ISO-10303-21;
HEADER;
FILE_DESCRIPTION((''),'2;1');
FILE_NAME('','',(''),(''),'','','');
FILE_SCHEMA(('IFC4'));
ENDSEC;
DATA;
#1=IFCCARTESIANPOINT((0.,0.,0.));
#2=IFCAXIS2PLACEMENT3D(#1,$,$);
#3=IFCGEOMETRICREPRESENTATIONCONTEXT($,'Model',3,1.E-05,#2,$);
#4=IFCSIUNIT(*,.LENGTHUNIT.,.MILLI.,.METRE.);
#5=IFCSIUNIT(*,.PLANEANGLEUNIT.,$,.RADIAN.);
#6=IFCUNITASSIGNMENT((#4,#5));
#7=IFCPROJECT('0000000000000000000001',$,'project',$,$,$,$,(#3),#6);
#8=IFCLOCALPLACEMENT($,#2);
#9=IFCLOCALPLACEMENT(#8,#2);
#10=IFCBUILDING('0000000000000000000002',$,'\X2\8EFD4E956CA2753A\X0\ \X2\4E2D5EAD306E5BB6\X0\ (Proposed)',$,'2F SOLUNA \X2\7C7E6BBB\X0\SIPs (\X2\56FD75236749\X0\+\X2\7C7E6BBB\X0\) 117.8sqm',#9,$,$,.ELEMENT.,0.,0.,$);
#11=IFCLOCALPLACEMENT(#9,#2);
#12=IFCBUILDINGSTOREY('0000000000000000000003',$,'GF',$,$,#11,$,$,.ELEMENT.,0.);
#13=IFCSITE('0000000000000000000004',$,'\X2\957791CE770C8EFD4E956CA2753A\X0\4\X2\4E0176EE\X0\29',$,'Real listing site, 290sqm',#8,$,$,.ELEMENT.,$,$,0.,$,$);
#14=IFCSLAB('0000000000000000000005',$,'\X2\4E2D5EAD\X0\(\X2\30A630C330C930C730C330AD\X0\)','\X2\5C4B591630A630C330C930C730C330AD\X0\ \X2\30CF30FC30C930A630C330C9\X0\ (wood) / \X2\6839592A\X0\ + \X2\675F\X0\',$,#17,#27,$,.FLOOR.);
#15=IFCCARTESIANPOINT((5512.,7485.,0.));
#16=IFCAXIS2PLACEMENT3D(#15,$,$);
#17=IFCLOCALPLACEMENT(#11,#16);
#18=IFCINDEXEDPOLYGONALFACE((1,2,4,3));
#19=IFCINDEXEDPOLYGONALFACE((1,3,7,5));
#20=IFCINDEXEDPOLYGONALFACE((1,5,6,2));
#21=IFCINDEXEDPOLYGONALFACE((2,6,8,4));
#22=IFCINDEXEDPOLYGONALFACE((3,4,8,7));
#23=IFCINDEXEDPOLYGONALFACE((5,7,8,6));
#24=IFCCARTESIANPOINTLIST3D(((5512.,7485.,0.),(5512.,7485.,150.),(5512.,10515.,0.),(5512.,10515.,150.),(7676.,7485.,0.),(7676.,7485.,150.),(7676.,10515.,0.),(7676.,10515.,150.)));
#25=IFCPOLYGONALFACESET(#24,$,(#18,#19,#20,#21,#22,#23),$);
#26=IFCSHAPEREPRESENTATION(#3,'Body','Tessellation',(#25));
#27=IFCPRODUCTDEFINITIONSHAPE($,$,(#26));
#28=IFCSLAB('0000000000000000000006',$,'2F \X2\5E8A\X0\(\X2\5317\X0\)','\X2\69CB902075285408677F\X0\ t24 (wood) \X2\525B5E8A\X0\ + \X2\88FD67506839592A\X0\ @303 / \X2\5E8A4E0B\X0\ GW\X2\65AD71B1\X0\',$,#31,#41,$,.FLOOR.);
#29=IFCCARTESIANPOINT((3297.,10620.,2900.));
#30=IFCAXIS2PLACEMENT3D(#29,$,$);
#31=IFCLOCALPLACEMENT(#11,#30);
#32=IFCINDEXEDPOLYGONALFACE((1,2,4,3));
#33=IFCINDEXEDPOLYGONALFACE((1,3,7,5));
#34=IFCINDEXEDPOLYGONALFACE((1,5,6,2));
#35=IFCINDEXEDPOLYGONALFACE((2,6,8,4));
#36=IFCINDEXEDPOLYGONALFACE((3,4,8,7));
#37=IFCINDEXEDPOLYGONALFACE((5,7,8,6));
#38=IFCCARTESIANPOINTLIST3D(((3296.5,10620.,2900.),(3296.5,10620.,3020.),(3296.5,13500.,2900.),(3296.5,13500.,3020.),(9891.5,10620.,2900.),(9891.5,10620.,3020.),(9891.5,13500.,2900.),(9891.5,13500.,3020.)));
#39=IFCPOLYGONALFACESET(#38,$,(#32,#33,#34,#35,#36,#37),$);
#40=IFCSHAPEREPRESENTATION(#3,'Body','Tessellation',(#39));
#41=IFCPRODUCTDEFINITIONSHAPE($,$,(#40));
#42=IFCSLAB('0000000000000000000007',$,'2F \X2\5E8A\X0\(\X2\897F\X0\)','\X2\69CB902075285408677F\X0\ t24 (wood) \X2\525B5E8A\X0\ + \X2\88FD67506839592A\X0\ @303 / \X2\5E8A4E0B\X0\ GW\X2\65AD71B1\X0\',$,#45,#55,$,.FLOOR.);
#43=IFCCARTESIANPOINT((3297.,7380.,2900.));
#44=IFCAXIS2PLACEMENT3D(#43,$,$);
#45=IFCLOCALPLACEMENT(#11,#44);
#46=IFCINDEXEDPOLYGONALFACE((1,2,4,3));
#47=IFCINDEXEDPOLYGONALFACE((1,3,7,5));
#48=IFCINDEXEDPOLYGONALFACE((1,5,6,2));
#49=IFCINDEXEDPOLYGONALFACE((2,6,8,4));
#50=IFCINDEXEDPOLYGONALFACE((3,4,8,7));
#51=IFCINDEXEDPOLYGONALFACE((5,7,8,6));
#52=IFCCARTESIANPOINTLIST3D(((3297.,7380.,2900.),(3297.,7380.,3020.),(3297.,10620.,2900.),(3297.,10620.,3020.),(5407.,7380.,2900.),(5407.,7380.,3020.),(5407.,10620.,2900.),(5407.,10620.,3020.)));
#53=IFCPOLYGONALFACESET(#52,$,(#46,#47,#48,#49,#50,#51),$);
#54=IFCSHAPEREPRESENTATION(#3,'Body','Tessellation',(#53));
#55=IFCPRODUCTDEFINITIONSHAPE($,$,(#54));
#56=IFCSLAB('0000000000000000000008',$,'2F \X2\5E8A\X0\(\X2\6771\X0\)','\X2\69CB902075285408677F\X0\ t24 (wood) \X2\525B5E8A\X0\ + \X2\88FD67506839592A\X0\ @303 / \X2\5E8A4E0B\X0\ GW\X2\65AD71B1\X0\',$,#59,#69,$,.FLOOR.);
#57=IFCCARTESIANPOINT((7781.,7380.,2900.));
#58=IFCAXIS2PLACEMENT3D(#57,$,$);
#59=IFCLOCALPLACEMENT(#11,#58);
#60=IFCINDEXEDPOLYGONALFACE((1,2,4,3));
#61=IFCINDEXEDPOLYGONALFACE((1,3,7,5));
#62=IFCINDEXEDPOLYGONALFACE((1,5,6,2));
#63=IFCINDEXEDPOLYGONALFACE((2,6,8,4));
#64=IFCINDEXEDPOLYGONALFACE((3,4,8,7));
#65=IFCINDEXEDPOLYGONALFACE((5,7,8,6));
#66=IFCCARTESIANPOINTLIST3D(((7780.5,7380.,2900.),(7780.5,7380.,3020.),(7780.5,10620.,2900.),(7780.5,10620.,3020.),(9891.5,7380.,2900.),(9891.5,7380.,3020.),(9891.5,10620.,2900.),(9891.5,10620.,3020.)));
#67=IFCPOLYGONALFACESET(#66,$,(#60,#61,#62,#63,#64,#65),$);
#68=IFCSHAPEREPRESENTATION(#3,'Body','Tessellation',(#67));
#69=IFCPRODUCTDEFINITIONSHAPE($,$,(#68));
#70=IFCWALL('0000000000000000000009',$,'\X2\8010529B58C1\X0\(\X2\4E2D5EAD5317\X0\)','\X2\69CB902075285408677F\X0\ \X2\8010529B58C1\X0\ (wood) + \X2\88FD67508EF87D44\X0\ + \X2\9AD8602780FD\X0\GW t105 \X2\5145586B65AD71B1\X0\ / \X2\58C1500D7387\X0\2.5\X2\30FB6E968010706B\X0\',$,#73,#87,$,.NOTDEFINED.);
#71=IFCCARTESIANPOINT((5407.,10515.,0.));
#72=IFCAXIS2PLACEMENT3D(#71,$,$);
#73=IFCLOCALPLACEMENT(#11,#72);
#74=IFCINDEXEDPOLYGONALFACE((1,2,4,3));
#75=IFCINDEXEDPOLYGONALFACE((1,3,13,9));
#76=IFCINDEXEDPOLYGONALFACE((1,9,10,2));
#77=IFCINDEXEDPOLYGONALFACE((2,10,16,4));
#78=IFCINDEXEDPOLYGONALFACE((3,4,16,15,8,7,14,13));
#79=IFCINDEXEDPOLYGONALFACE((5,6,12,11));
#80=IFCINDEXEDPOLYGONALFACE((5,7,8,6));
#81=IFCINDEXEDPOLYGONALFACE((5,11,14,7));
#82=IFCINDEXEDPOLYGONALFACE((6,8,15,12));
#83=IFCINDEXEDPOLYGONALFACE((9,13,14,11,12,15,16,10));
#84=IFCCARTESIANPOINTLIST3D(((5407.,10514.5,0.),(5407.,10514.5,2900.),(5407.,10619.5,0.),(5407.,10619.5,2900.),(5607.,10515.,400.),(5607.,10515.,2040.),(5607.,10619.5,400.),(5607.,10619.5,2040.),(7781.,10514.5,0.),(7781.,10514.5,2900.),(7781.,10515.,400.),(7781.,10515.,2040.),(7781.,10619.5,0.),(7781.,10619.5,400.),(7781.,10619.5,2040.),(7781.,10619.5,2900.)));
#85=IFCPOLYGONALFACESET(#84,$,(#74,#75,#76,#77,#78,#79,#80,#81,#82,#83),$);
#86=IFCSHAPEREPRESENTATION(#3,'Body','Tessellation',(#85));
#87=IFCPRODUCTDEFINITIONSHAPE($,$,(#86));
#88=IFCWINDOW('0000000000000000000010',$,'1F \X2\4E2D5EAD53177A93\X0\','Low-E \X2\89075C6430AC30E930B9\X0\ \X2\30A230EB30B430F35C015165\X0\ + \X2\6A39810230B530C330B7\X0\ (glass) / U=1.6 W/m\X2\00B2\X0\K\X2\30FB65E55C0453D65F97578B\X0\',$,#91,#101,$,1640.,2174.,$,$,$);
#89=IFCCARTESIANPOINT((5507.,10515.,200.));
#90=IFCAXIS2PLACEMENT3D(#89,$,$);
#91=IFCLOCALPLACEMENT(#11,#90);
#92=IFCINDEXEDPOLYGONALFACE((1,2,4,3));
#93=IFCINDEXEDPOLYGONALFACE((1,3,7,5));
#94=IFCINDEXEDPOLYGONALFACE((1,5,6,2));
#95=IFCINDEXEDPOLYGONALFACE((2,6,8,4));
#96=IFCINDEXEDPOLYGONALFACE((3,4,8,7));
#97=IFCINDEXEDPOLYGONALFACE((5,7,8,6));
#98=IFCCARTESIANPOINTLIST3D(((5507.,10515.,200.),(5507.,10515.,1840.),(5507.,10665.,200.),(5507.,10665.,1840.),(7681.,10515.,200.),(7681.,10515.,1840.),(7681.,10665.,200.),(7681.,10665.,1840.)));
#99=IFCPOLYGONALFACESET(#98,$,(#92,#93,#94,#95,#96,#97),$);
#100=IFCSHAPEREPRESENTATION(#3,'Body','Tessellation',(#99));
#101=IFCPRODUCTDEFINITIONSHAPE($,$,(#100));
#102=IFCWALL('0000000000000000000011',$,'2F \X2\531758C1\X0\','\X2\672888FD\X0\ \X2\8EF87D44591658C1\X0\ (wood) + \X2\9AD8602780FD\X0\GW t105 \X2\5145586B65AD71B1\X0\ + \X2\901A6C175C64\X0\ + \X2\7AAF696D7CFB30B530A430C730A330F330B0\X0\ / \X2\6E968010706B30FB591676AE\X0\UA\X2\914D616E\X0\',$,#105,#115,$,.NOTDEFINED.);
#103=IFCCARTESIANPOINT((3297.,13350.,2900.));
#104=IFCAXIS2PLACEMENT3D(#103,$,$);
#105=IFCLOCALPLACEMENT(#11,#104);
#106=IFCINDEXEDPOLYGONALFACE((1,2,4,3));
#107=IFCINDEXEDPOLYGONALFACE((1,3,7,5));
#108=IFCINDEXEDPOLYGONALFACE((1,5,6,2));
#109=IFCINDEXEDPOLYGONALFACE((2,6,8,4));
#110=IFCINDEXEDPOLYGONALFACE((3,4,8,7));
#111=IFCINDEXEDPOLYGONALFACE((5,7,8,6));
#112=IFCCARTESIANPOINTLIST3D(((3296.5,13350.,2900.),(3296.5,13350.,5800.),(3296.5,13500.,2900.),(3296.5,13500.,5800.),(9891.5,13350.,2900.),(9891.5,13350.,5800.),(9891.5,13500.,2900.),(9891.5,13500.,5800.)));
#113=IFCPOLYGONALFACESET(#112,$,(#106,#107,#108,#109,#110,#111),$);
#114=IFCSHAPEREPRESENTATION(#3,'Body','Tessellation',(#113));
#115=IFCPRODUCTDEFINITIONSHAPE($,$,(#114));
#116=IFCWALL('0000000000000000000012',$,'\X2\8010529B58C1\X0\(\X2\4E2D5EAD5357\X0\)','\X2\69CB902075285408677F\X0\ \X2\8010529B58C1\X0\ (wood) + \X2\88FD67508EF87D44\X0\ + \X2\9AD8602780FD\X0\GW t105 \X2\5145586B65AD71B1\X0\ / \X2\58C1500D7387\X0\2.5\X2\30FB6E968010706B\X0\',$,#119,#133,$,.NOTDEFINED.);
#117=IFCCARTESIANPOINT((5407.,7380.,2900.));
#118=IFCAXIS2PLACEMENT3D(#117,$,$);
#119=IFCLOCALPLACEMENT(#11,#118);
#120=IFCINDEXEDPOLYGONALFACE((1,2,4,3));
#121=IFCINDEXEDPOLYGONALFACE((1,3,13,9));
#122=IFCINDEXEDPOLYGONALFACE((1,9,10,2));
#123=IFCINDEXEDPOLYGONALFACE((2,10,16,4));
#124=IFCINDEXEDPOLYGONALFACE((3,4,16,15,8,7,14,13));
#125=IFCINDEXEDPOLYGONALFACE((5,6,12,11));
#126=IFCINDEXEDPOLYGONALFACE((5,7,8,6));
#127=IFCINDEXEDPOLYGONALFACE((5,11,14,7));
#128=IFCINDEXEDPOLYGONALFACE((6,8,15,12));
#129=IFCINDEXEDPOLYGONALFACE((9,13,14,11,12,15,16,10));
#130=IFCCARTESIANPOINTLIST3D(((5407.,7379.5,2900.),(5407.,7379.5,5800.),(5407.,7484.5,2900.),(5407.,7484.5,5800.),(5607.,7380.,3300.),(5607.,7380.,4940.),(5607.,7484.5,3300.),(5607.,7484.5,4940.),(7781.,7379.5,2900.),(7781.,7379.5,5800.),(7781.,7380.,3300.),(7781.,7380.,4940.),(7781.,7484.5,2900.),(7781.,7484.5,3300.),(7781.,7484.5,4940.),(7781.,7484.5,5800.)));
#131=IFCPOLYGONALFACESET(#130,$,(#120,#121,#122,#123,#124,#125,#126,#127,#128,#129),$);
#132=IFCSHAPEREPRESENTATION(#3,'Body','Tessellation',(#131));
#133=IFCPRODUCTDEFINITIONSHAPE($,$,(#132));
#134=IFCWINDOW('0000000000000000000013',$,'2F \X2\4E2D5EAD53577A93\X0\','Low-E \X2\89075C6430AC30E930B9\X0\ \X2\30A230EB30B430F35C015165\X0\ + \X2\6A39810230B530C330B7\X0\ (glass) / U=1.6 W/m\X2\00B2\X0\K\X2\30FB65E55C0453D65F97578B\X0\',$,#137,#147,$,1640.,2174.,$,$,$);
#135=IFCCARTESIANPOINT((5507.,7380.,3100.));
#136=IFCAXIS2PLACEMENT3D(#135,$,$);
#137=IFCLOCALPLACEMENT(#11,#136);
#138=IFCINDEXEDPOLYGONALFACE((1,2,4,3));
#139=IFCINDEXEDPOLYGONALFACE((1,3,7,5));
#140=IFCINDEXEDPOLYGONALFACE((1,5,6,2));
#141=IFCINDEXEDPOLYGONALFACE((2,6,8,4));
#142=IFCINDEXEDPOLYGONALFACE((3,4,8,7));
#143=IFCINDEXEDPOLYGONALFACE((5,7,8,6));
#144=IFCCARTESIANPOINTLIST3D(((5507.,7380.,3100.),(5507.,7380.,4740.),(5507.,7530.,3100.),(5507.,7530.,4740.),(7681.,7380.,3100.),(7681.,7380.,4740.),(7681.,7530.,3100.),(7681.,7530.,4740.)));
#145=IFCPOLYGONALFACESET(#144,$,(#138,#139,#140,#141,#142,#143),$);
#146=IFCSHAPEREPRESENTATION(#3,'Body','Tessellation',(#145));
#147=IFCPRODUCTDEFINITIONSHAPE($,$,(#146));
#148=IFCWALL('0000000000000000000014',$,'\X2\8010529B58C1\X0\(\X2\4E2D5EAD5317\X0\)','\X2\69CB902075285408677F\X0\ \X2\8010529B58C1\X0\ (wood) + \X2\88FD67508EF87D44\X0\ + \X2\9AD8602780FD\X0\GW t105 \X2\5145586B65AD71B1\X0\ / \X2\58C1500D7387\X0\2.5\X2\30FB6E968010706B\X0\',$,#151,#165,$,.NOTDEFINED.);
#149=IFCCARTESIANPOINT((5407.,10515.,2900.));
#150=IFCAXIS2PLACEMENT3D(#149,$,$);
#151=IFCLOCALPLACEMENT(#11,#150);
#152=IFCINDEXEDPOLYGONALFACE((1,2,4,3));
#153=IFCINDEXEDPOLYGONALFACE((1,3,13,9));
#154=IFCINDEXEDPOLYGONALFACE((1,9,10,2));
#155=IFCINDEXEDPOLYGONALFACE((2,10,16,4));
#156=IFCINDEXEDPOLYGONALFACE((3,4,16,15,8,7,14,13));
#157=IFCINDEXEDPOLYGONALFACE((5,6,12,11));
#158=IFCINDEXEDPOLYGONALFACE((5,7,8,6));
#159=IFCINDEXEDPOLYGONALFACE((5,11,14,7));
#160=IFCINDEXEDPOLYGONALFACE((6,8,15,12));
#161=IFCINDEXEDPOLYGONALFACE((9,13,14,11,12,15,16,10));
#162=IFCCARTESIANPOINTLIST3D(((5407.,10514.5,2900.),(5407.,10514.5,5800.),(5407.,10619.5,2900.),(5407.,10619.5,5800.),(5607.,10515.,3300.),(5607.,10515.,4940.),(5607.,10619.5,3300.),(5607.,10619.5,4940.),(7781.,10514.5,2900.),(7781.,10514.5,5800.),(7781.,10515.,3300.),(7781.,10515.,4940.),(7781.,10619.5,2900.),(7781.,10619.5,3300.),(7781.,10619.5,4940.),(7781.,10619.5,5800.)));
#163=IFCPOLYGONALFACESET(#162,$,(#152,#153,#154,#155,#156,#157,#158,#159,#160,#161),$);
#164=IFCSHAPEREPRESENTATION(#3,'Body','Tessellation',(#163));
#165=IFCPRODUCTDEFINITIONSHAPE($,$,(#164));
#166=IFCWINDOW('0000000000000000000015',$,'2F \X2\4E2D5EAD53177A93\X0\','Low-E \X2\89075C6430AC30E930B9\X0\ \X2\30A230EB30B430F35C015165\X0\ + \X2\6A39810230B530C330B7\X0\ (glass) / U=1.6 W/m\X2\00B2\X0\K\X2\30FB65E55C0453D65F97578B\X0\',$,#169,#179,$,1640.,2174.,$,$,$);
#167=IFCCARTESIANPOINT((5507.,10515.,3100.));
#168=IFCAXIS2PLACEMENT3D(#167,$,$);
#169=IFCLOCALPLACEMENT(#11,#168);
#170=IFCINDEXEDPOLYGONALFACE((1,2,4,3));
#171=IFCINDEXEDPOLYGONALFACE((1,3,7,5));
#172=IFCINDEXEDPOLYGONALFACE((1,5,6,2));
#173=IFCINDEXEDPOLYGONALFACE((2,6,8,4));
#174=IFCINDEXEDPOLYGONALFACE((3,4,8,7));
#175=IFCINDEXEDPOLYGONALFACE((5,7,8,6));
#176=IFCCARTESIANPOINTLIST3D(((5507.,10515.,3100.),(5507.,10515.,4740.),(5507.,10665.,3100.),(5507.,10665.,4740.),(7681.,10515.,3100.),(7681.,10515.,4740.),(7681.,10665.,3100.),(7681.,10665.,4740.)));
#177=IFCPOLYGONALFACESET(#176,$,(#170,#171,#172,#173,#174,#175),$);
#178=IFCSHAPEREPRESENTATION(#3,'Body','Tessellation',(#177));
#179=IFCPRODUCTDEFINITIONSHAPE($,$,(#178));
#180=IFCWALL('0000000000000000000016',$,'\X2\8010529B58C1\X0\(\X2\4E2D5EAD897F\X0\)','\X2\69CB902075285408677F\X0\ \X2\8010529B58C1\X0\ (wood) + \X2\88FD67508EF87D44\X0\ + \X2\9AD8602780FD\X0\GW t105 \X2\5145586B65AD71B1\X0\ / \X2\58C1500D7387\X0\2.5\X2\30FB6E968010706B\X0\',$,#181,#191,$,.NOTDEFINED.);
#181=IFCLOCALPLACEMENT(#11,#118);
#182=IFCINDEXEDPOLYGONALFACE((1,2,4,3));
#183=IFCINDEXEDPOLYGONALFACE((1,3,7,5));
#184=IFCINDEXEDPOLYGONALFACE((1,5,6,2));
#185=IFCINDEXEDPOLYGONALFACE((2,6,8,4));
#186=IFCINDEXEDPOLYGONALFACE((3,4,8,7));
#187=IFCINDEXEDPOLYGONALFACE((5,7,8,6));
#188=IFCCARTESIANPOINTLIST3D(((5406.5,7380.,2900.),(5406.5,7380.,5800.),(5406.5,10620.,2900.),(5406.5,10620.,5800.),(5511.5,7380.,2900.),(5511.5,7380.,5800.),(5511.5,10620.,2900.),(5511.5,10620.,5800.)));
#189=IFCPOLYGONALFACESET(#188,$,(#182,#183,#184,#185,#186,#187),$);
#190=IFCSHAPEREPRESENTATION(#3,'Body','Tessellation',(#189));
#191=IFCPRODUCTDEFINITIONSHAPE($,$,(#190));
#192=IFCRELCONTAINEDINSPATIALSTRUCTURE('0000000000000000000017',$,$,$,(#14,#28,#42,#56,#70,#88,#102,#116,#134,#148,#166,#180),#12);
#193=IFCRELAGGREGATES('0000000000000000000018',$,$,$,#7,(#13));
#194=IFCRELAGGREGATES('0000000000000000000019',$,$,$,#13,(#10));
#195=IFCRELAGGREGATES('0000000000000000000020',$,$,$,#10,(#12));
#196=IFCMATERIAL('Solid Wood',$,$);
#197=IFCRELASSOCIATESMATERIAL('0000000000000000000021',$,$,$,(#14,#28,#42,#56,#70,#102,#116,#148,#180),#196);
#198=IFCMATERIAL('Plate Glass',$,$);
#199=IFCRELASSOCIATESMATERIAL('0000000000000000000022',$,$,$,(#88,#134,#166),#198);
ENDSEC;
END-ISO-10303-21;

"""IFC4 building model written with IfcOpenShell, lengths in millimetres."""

from ifc_helpers import new_model, si_unit, frame, frame_2d, origin, place, context, project, spatial, rectangle, extrude, material, element, fill, save


model = new_model("IFC4")

# Units and contexts
model_context = context("Model", 3, precision=1e-05, world=origin())
ifc_project = project(units=[si_unit("LENGTHUNIT", "METRE", prefix="MILLI"), si_unit("PLANEANGLEUNIT", "RADIAN")], contexts=[model_context])

# Site, building, storey
site_placement = place(None, origin())
site = spatial("IfcSite", under=ifc_project, at=site_placement, Name="長野県軽井沢町4丁目29", ObjectType="Real listing site, 290sqm", CompositionType="ELEMENT", RefElevation=0.0)
building_placement = place(site_placement, origin())
building = spatial("IfcBuilding", under=site, at=building_placement, Name="軽井沢町 中庭の家 (Proposed)", ObjectType="2F SOLUNA 籾殻SIPs (国産杉+籾殻) 117.8sqm", CompositionType="ELEMENT", ElevationOfRefHeight=0.0, ElevationOfTerrain=0.0)
storey_placement = place(building_placement, origin())
storey = spatial("IfcBuildingStorey", under=building, at=storey_placement, Name="GF", CompositionType="ELEMENT", Elevation=0.0)

# Slabs
ifc_material_1 = material(Name="Solid Wood")
slab_1_placement = place(storey_placement, frame((5512.0, 7485.0, 0.0)))
element("IfcSlab", 1, at=slab_1_placement, inside=storey, material=ifc_material_1, Name="中庭(ウッドデッキ)", Description="屋外ウッドデッキ ハードウッド (wood) / 根太 + 束", PredefinedType="FLOOR", context=model_context, shape_type="SweptSolid", body=[
    extrude(rectangle(XDim=2164.0, YDim=3030.0, at=frame_2d((1082.0, 1515.0))), frame((5512.0, 7485.0, 0.0)), (0.0, 0.0, 1.0), 150.0),
])
slab_2_placement = place(storey_placement, frame((3297.0, 10620.0, 2900.0)))
element("IfcSlab", 2, at=slab_2_placement, inside=storey, material=ifc_material_1, Name="2F 床(北)", Description="構造用合板 t24 (wood) 剛床 + 製材根太 @303 / 床下 GW断熱", PredefinedType="FLOOR", context=model_context, shape_type="SweptSolid", body=[
    extrude(rectangle(XDim=6595.0, YDim=2880.0, at=frame_2d((3297.0, 1440.0))), frame((3297.0, 10620.0, 2900.0)), (0.0, 0.0, 1.0), 120.0),
])
slab_3_placement = place(storey_placement, frame((3297.0, 7380.0, 2900.0)))
element("IfcSlab", 3, at=slab_3_placement, inside=storey, material=ifc_material_1, Name="2F 床(西)", Description="構造用合板 t24 (wood) 剛床 + 製材根太 @303 / 床下 GW断熱", PredefinedType="FLOOR", context=model_context, shape_type="SweptSolid", body=[
    extrude(rectangle(XDim=2110.0, YDim=3240.0, at=frame_2d((1055.0, 1620.0))), frame((3297.0, 7380.0, 2900.0)), (0.0, 0.0, 1.0), 120.0),
])
slab_4_placement = place(storey_placement, frame((7781.0, 7380.0, 2900.0)))
element("IfcSlab", 4, at=slab_4_placement, inside=storey, material=ifc_material_1, Name="2F 床(東)", Description="構造用合板 t24 (wood) 剛床 + 製材根太 @303 / 床下 GW断熱", PredefinedType="FLOOR", context=model_context, shape_type="SweptSolid", body=[
    extrude(rectangle(XDim=2111.0, YDim=3240.0, at=frame_2d((1055.0, 1620.0))), frame((7781.0, 7380.0, 2900.0)), (0.0, 0.0, 1.0), 120.0),
])

# Wall, opening, window
wall_1_placement = place(storey_placement, frame((5407.0, 10515.0, 0.0)))
wall_1 = element("IfcWall", 5, at=wall_1_placement, inside=storey, material=ifc_material_1, Name="耐力壁(中庭北)", Description="構造用合板 耐力壁 (wood) + 製材軸組 + 高性能GW t105 充填断熱 / 壁倍率2.5・準耐火", PredefinedType="NOTDEFINED", context=model_context, shape_type="SweptSolid", body=[
    extrude(rectangle(XDim=2374.0, YDim=105.0, at=frame_2d((1187.0, 52.0))), frame((5407.0, 10515.0, 0.0)), (0.0, 0.0, 1.0), 2900.0),
])
opening_1_placement = place(storey_placement, frame((5507.0, 10515.0, 200.0)))
opening_1 = element("IfcOpeningElement", 6, at=opening_1_placement, cuts=wall_1, PredefinedType="NOTDEFINED", context=model_context, shape_type="SweptSolid", body=[
    extrude(rectangle(XDim=2174.0, YDim=150.0, at=frame_2d((1087.0, 75.0))), frame((5507.0, 10515.0, 200.0)), (0.0, 0.0, 1.0), 1640.0),
])
ifc_material_2 = material(Name="Plate Glass")
window_1_placement = place(storey_placement, frame((5507.0, 10515.0, 200.0)))
window_1 = element("IfcWindow", 7, at=window_1_placement, inside=storey, material=ifc_material_2, Name="1F 中庭北窓", Description="Low-E 複層ガラス アルゴン封入 + 樹脂サッシ (glass) / U=1.6 W/m²K・日射取得型", OverallHeight=1640.0, OverallWidth=2174.0, context=model_context, shape_type="SweptSolid", body=[
    extrude(rectangle(XDim=2174.0, YDim=150.0, at=frame_2d((1087.0, 75.0))), frame((5507.0, 10515.0, 200.0)), (0.0, 0.0, 1.0), 1640.0),
])
fill(opening_1, window_1)

# Wall
wall_2_placement = place(storey_placement, frame((3297.0, 13350.0, 2900.0)))
element("IfcWall", 8, at=wall_2_placement, inside=storey, material=ifc_material_1, Name="2F 北壁", Description="木製 軸組外壁 (wood) + 高性能GW t105 充填断熱 + 通気層 + 窯業系サイディング / 準耐火・外皮UA配慮", PredefinedType="NOTDEFINED", context=model_context, shape_type="SweptSolid", body=[
    extrude(rectangle(XDim=6595.0, YDim=150.0, at=frame_2d((3297.0, 75.0))), frame((3297.0, 13350.0, 2900.0)), (0.0, 0.0, 1.0), 2900.0),
])

# Walls, openings, windows
wall_3_placement = place(storey_placement, frame((5407.0, 7380.0, 2900.0)))
wall_3 = element("IfcWall", 9, at=wall_3_placement, inside=storey, material=ifc_material_1, Name="耐力壁(中庭南)", Description="構造用合板 耐力壁 (wood) + 製材軸組 + 高性能GW t105 充填断熱 / 壁倍率2.5・準耐火", PredefinedType="NOTDEFINED", context=model_context, shape_type="SweptSolid", body=[
    extrude(rectangle(XDim=2374.0, YDim=105.0, at=frame_2d((1187.0, 52.0))), frame((5407.0, 7380.0, 2900.0)), (0.0, 0.0, 1.0), 2900.0),
])
opening_2_placement = place(storey_placement, frame((5507.0, 7380.0, 3100.0)))
opening_2 = element("IfcOpeningElement", 10, at=opening_2_placement, cuts=wall_3, PredefinedType="NOTDEFINED", context=model_context, shape_type="SweptSolid", body=[
    extrude(rectangle(XDim=2174.0, YDim=150.0, at=frame_2d((1087.0, 75.0))), frame((5507.0, 7380.0, 3100.0)), (0.0, 0.0, 1.0), 1640.0),
])
window_2_placement = place(storey_placement, frame((5507.0, 7380.0, 3100.0)))
window_2 = element("IfcWindow", 11, at=window_2_placement, inside=storey, material=ifc_material_2, Name="2F 中庭南窓", Description="Low-E 複層ガラス アルゴン封入 + 樹脂サッシ (glass) / U=1.6 W/m²K・日射取得型", OverallHeight=1640.0, OverallWidth=2174.0, context=model_context, shape_type="SweptSolid", body=[
    extrude(rectangle(XDim=2174.0, YDim=150.0, at=frame_2d((1087.0, 75.0))), frame((5507.0, 7380.0, 3100.0)), (0.0, 0.0, 1.0), 1640.0),
])
fill(opening_2, window_2)
wall_4_placement = place(storey_placement, frame((5407.0, 10515.0, 2900.0)))
wall_4 = element("IfcWall", 12, at=wall_4_placement, inside=storey, material=ifc_material_1, Name="耐力壁(中庭北)", Description="構造用合板 耐力壁 (wood) + 製材軸組 + 高性能GW t105 充填断熱 / 壁倍率2.5・準耐火", PredefinedType="NOTDEFINED", context=model_context, shape_type="SweptSolid", body=[
    extrude(rectangle(XDim=2374.0, YDim=105.0, at=frame_2d((1187.0, 52.0))), frame((5407.0, 10515.0, 2900.0)), (0.0, 0.0, 1.0), 2900.0),
])
opening_3_placement = place(storey_placement, frame((5507.0, 10515.0, 3100.0)))
opening_3 = element("IfcOpeningElement", 13, at=opening_3_placement, cuts=wall_4, PredefinedType="NOTDEFINED", context=model_context, shape_type="SweptSolid", body=[
    extrude(rectangle(XDim=2174.0, YDim=150.0, at=frame_2d((1087.0, 75.0))), frame((5507.0, 10515.0, 3100.0)), (0.0, 0.0, 1.0), 1640.0),
])
window_3_placement = place(storey_placement, frame((5507.0, 10515.0, 3100.0)))
window_3 = element("IfcWindow", 14, at=window_3_placement, inside=storey, material=ifc_material_2, Name="2F 中庭北窓", Description="Low-E 複層ガラス アルゴン封入 + 樹脂サッシ (glass) / U=1.6 W/m²K・日射取得型", OverallHeight=1640.0, OverallWidth=2174.0, context=model_context, shape_type="SweptSolid", body=[
    extrude(rectangle(XDim=2174.0, YDim=150.0, at=frame_2d((1087.0, 75.0))), frame((5507.0, 10515.0, 3100.0)), (0.0, 0.0, 1.0), 1640.0),
])
fill(opening_3, window_3)

# Wall
wall_5_placement = place(storey_placement, frame((5407.0, 7380.0, 2900.0)))
element("IfcWall", 15, at=wall_5_placement, inside=storey, material=ifc_material_1, Name="耐力壁(中庭西)", Description="構造用合板 耐力壁 (wood) + 製材軸組 + 高性能GW t105 充填断熱 / 壁倍率2.5・準耐火", PredefinedType="NOTDEFINED", context=model_context, shape_type="SweptSolid", body=[
    extrude(rectangle(XDim=105.0, YDim=3240.0, at=frame_2d((52.0, 1620.0))), frame((5407.0, 7380.0, 2900.0)), (0.0, 0.0, 1.0), 2900.0),
])

save(model, "model.ifc")
